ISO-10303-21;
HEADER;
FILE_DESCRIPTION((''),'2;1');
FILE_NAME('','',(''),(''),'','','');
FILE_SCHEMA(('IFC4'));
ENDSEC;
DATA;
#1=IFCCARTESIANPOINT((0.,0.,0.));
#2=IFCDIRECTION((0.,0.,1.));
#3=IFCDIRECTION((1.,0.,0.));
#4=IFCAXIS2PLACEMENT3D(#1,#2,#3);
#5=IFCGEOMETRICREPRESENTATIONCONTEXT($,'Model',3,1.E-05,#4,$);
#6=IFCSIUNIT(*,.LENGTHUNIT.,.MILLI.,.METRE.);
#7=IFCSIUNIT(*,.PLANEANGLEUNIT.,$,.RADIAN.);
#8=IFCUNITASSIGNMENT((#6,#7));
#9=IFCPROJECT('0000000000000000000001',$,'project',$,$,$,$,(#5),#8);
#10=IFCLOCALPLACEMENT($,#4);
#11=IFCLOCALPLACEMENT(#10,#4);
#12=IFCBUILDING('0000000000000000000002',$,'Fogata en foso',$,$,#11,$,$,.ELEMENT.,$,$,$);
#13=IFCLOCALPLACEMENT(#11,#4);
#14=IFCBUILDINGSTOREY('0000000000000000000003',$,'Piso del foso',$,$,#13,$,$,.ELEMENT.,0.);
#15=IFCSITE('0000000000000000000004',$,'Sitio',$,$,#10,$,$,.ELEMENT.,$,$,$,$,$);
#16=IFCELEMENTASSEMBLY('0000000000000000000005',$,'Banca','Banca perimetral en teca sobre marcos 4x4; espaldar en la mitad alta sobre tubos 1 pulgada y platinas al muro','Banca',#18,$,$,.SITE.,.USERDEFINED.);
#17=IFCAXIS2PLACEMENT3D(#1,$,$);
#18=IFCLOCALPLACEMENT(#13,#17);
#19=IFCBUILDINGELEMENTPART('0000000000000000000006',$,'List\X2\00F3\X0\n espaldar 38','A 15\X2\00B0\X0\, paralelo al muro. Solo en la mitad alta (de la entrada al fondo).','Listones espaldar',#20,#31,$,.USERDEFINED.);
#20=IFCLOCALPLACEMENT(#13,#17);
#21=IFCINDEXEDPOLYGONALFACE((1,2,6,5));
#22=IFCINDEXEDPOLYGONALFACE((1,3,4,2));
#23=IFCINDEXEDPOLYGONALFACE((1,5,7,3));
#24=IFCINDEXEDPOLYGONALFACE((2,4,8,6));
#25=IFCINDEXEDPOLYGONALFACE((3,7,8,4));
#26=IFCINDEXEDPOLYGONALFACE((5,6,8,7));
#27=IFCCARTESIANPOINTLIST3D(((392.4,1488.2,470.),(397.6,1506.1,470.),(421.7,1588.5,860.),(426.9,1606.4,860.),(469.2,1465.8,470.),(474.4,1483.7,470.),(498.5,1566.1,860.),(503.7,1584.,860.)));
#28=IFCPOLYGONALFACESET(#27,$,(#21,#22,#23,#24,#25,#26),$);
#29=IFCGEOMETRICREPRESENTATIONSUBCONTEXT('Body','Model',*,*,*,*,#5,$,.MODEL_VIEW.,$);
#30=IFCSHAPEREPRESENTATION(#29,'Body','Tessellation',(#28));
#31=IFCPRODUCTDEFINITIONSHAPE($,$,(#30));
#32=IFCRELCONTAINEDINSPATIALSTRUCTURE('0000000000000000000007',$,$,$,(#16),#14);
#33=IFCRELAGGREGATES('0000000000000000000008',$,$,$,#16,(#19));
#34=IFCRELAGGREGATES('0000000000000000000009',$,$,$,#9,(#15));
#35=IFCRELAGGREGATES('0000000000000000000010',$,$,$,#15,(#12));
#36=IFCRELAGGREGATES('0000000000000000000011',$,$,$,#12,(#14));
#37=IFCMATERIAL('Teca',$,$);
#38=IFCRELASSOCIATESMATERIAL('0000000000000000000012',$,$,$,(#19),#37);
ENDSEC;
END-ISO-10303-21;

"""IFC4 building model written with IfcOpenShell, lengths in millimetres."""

from ifc_helpers import new_model, si_unit, frame, origin_with_axes, place, context, subcontext, project, spatial, polyline, outline, extrude, material, element, aggregate, save


model = new_model("IFC4")

# Units and contexts
model_context = context("Model", 3, precision=1e-05, world=origin_with_axes())
body_context = subcontext(model_context, "Body", "Model", "MODEL_VIEW")
ifc_project = project(units=[si_unit("LENGTHUNIT", "METRE", prefix="MILLI"), si_unit("PLANEANGLEUNIT", "RADIAN")], contexts=[model_context])

# Site, building, storey
site_placement = place(None, origin_with_axes())
site = spatial("IfcSite", under=ifc_project, at=site_placement, Name="Sitio", CompositionType="ELEMENT")
building_placement = place(site_placement, origin_with_axes())
building = spatial("IfcBuilding", under=site, at=building_placement, Name="Fogata en foso", CompositionType="ELEMENT")
storey_placement = place(building_placement, origin_with_axes())
storey = spatial("IfcBuildingStorey", under=building, at=storey_placement, Name="Piso del foso", CompositionType="ELEMENT", Elevation=0.0)

# Element assembly, building element part
assembly_1_placement = place(storey_placement, origin_with_axes())
assembly_1 = element("IfcElementAssembly", 1, at=assembly_1_placement, inside=storey, Name="Banca", Description="Banca perimetral en teca sobre marcos 4x4; espaldar en la mitad alta sobre tubos 1 pulgada y platinas al muro", ObjectType="Banca", AssemblyPlace="SITE", PredefinedType="USERDEFINED")
ifc_material_1 = material(Name="Teca")
building_element_part_1_placement = place(storey_placement, frame((-38.4, 11.2, 0.0), z_axis=(0.96, -0.28, 0.0), x_axis=(0.28, 0.96, 0.0)))
building_element_part_1 = element("IfcBuildingElementPart", 2, at=building_element_part_1_placement, material=ifc_material_1, Name="Listón espaldar 38", Description="A 15°, paralelo al muro. Solo en la mitad alta (de la entrada al fondo).", ObjectType="Listones espaldar", PredefinedType="USERDEFINED", context=body_context, shape_type="SweptSolid", body=[
    extrude(outline(polyline([(1538.5, 470.0), (1557.2, 470.0), (1661.7, 860.0), (1643.0, 860.0), (1538.5, 470.0)])), origin_with_axes(), (0.0, 0.0, 1.0), 80.0),
])
aggregate(assembly_1, [building_element_part_1])

save(model, "model.ifc")
